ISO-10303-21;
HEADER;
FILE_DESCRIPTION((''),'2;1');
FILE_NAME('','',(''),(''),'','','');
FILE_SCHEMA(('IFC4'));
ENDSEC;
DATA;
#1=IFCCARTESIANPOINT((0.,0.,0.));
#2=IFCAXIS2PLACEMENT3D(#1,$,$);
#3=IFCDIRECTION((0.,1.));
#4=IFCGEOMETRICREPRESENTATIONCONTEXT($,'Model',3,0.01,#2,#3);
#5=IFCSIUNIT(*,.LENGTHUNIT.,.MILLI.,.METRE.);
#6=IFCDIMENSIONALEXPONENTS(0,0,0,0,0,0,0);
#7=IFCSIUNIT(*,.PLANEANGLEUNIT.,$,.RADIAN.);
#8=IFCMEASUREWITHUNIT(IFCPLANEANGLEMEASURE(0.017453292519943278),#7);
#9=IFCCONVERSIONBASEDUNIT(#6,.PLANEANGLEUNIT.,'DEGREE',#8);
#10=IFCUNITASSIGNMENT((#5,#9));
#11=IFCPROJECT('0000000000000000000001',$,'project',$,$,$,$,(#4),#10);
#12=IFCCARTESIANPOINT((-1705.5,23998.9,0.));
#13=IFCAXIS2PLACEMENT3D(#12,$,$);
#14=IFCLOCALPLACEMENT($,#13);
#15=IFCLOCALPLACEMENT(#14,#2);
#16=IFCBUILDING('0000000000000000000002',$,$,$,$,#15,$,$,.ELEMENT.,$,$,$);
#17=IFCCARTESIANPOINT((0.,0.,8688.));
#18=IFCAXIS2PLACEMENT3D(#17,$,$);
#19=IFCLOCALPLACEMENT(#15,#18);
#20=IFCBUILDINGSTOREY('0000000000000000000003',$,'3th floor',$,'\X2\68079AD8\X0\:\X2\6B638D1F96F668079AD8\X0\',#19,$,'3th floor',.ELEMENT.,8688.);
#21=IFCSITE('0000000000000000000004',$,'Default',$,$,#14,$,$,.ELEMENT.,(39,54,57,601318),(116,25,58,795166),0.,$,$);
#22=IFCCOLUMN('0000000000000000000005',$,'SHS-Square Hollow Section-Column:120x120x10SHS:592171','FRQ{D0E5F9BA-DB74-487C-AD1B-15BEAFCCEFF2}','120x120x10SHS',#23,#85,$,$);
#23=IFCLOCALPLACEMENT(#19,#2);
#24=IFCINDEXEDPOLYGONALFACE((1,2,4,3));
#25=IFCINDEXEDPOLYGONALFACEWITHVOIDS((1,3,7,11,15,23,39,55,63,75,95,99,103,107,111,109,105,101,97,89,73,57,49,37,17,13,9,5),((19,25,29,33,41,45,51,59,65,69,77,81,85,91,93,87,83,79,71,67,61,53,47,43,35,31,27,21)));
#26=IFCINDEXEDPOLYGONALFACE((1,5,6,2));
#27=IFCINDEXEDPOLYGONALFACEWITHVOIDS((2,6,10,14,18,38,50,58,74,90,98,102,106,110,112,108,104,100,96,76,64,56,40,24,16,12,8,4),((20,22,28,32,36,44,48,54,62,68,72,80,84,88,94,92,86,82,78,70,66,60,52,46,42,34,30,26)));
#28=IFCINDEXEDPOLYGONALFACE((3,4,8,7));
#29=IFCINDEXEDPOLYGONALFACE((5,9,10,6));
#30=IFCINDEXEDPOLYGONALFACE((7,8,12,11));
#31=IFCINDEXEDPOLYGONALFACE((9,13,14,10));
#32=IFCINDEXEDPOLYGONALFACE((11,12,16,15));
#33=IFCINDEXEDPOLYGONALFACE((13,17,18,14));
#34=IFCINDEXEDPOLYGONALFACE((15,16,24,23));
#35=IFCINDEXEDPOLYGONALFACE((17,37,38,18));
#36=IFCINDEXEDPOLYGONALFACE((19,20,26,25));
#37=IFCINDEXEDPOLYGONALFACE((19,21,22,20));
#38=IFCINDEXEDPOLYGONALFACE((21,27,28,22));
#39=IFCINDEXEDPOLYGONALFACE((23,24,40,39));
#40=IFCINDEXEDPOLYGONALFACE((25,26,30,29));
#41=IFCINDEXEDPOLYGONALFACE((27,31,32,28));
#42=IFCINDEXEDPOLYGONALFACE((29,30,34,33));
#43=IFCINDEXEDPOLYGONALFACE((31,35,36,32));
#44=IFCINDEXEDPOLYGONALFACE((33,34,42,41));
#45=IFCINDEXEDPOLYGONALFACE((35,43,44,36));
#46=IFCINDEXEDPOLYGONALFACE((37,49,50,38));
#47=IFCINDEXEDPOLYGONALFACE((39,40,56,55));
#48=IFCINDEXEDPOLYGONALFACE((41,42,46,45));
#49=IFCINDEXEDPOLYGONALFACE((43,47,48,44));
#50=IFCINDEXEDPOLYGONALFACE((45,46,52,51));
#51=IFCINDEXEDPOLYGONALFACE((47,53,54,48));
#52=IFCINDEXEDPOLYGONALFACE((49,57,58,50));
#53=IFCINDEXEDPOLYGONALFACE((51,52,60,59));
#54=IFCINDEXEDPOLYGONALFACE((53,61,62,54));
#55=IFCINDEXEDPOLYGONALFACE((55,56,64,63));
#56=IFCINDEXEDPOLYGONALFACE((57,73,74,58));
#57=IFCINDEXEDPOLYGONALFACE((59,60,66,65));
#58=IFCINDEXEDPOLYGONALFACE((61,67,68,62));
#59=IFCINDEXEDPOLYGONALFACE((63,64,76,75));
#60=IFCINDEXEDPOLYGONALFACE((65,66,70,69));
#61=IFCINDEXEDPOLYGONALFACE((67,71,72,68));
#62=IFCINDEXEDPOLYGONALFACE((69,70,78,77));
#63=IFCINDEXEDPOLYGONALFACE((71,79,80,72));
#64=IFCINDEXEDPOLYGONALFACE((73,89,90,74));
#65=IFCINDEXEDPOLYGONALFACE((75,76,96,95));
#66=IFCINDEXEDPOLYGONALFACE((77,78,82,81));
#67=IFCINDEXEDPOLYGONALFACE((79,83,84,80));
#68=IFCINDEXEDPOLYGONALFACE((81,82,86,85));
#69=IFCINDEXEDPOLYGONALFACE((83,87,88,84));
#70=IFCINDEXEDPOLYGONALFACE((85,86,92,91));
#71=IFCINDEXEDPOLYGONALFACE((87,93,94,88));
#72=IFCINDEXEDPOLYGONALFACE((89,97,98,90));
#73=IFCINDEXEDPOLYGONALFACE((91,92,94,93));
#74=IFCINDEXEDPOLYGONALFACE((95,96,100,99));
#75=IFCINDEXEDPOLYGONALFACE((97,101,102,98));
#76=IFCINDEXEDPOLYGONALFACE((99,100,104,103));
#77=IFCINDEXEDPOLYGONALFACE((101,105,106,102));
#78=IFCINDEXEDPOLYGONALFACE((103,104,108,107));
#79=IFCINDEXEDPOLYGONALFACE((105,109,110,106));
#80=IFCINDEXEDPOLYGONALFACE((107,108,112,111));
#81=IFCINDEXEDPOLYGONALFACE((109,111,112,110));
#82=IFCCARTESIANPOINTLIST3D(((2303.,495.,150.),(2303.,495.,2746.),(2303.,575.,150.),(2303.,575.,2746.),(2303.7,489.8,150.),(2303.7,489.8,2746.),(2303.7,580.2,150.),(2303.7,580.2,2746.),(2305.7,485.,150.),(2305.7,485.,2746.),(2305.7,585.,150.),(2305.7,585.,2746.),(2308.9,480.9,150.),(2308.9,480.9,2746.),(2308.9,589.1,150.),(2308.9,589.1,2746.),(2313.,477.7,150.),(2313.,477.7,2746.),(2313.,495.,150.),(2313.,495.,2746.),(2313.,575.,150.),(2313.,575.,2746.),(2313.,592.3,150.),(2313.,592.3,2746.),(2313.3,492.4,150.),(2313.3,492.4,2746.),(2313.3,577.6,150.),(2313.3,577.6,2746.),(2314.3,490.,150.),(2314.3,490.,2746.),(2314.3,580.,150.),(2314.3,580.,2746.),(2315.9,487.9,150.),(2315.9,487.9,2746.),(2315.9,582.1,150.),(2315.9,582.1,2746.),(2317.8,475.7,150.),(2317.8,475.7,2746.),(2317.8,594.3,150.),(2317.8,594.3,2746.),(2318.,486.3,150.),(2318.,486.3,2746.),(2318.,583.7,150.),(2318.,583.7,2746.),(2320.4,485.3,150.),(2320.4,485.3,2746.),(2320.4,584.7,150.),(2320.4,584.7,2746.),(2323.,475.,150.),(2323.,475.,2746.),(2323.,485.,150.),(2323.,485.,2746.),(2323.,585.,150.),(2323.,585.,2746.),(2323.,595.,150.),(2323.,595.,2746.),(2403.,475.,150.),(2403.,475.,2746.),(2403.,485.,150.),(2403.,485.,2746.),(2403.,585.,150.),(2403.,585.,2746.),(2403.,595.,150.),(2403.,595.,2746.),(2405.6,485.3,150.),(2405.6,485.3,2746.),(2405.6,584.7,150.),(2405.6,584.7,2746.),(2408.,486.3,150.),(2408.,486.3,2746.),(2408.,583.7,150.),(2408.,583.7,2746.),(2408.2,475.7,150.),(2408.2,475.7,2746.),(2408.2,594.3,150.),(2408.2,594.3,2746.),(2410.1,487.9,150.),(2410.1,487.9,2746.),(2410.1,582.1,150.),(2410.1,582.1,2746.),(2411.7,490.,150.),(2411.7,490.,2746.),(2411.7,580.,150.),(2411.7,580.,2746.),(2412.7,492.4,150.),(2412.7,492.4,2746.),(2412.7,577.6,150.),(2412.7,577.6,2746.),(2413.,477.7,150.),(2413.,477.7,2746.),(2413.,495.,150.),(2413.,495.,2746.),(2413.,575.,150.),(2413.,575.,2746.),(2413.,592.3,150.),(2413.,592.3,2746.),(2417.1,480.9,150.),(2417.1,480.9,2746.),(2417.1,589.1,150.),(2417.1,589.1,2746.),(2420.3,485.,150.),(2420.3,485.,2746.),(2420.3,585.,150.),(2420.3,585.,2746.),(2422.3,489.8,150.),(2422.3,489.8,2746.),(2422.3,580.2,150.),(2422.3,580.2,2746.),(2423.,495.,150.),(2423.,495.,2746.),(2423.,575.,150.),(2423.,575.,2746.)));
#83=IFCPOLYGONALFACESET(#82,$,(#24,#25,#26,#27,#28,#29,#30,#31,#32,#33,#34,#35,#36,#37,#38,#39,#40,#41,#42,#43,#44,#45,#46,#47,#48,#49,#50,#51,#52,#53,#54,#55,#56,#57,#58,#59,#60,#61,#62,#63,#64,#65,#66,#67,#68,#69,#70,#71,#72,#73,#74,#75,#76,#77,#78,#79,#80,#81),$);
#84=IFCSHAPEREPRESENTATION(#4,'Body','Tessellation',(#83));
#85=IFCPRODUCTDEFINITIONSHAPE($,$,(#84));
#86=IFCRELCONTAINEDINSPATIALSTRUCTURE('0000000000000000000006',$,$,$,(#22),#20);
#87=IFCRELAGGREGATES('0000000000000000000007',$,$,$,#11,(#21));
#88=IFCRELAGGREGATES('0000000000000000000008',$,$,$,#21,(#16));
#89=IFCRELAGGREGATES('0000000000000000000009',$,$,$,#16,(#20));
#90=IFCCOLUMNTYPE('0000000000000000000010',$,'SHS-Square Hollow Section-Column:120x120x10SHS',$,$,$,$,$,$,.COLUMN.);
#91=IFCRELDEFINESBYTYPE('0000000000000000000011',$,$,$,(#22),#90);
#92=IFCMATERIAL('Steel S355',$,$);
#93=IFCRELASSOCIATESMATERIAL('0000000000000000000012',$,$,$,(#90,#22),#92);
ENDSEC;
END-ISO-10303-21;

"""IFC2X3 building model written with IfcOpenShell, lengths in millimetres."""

from ifc_helpers import new_model, entity, si_unit, converted_unit, direction, frame, origin, origin_2d, place, context, project, spatial, hollow_rectangle, extrude, clip, halfspace, material, type_object, element, save


model = new_model("IFC2X3")

# Units and contexts
model_context = context("Model", 3, precision=0.01, world=origin(), true_north=direction((0.0, 1.0)))
ifc_project = project(units=[si_unit("LENGTHUNIT", "METRE", prefix="MILLI"), converted_unit("PLANEANGLEUNIT", "DEGREE", entity("IfcPlaneAngleMeasure", 0.017453292519943278), si_unit("PLANEANGLEUNIT", "RADIAN"), dimensions=[0, 0, 0, 0, 0, 0, 0])], contexts=[model_context])

# Site, building, storey
site_placement = place(None, frame((-1705.5, 23998.9, 0.0)))
site = spatial("IfcSite", under=ifc_project, at=site_placement, Name="Default", CompositionType="ELEMENT", RefLatitude=(39, 54, 57, 601318), RefLongitude=(116, 25, 58, 795166), RefElevation=0.0)
building_placement = place(site_placement, origin())
building = spatial("IfcBuilding", under=site, at=building_placement, CompositionType="ELEMENT")
storey_placement = place(building_placement, frame((0.0, 0.0, 8688.0)))
storey = spatial("IfcBuildingStorey", under=building, at=storey_placement, Name="3th floor", ObjectType="标高:正负零标高", LongName="3th floor", CompositionType="ELEMENT", Elevation=8688.0)

# Shared definitions
ifc_material_1 = material(Name="Steel S355")

# Column
column_type_1 = type_object("IfcColumnType", Name="SHS-Square Hollow Section-Column:120x120x10SHS", PredefinedType="COLUMN", material=ifc_material_1)
column_1_placement = place(storey_placement, frame((2363.0, 535.0, 2746.0), z_axis=(0.0, 0.0, 1.0), x_axis=(0.0, -1.0, 0.0)))
element("IfcColumn", 1, at=column_1_placement, inside=storey, type_object=column_type_1, material=ifc_material_1, Name="SHS-Square Hollow Section-Column:120x120x10SHS:592171", Description="FRQ{D0E5F9BA-DB74-487C-AD1B-15BEAFCCEFF2}", ObjectType="120x120x10SHS", context=model_context, shape_type="Clipping", body=[
    clip(extrude(hollow_rectangle(XDim=120.0, YDim=120.0, WallThickness=10.0, InnerFilletRadius=10.0, OuterFilletRadius=20.0, at=origin_2d()), origin(), (0.0, 0.0, -1.0), 2680.9), halfspace(frame((535.0, -2363.0, -2596.0), z_axis=(0.0, 0.0, 1.0), x_axis=(0.0, 1.0, 0.0)), True)),
])

save(model, "model.ifc")
